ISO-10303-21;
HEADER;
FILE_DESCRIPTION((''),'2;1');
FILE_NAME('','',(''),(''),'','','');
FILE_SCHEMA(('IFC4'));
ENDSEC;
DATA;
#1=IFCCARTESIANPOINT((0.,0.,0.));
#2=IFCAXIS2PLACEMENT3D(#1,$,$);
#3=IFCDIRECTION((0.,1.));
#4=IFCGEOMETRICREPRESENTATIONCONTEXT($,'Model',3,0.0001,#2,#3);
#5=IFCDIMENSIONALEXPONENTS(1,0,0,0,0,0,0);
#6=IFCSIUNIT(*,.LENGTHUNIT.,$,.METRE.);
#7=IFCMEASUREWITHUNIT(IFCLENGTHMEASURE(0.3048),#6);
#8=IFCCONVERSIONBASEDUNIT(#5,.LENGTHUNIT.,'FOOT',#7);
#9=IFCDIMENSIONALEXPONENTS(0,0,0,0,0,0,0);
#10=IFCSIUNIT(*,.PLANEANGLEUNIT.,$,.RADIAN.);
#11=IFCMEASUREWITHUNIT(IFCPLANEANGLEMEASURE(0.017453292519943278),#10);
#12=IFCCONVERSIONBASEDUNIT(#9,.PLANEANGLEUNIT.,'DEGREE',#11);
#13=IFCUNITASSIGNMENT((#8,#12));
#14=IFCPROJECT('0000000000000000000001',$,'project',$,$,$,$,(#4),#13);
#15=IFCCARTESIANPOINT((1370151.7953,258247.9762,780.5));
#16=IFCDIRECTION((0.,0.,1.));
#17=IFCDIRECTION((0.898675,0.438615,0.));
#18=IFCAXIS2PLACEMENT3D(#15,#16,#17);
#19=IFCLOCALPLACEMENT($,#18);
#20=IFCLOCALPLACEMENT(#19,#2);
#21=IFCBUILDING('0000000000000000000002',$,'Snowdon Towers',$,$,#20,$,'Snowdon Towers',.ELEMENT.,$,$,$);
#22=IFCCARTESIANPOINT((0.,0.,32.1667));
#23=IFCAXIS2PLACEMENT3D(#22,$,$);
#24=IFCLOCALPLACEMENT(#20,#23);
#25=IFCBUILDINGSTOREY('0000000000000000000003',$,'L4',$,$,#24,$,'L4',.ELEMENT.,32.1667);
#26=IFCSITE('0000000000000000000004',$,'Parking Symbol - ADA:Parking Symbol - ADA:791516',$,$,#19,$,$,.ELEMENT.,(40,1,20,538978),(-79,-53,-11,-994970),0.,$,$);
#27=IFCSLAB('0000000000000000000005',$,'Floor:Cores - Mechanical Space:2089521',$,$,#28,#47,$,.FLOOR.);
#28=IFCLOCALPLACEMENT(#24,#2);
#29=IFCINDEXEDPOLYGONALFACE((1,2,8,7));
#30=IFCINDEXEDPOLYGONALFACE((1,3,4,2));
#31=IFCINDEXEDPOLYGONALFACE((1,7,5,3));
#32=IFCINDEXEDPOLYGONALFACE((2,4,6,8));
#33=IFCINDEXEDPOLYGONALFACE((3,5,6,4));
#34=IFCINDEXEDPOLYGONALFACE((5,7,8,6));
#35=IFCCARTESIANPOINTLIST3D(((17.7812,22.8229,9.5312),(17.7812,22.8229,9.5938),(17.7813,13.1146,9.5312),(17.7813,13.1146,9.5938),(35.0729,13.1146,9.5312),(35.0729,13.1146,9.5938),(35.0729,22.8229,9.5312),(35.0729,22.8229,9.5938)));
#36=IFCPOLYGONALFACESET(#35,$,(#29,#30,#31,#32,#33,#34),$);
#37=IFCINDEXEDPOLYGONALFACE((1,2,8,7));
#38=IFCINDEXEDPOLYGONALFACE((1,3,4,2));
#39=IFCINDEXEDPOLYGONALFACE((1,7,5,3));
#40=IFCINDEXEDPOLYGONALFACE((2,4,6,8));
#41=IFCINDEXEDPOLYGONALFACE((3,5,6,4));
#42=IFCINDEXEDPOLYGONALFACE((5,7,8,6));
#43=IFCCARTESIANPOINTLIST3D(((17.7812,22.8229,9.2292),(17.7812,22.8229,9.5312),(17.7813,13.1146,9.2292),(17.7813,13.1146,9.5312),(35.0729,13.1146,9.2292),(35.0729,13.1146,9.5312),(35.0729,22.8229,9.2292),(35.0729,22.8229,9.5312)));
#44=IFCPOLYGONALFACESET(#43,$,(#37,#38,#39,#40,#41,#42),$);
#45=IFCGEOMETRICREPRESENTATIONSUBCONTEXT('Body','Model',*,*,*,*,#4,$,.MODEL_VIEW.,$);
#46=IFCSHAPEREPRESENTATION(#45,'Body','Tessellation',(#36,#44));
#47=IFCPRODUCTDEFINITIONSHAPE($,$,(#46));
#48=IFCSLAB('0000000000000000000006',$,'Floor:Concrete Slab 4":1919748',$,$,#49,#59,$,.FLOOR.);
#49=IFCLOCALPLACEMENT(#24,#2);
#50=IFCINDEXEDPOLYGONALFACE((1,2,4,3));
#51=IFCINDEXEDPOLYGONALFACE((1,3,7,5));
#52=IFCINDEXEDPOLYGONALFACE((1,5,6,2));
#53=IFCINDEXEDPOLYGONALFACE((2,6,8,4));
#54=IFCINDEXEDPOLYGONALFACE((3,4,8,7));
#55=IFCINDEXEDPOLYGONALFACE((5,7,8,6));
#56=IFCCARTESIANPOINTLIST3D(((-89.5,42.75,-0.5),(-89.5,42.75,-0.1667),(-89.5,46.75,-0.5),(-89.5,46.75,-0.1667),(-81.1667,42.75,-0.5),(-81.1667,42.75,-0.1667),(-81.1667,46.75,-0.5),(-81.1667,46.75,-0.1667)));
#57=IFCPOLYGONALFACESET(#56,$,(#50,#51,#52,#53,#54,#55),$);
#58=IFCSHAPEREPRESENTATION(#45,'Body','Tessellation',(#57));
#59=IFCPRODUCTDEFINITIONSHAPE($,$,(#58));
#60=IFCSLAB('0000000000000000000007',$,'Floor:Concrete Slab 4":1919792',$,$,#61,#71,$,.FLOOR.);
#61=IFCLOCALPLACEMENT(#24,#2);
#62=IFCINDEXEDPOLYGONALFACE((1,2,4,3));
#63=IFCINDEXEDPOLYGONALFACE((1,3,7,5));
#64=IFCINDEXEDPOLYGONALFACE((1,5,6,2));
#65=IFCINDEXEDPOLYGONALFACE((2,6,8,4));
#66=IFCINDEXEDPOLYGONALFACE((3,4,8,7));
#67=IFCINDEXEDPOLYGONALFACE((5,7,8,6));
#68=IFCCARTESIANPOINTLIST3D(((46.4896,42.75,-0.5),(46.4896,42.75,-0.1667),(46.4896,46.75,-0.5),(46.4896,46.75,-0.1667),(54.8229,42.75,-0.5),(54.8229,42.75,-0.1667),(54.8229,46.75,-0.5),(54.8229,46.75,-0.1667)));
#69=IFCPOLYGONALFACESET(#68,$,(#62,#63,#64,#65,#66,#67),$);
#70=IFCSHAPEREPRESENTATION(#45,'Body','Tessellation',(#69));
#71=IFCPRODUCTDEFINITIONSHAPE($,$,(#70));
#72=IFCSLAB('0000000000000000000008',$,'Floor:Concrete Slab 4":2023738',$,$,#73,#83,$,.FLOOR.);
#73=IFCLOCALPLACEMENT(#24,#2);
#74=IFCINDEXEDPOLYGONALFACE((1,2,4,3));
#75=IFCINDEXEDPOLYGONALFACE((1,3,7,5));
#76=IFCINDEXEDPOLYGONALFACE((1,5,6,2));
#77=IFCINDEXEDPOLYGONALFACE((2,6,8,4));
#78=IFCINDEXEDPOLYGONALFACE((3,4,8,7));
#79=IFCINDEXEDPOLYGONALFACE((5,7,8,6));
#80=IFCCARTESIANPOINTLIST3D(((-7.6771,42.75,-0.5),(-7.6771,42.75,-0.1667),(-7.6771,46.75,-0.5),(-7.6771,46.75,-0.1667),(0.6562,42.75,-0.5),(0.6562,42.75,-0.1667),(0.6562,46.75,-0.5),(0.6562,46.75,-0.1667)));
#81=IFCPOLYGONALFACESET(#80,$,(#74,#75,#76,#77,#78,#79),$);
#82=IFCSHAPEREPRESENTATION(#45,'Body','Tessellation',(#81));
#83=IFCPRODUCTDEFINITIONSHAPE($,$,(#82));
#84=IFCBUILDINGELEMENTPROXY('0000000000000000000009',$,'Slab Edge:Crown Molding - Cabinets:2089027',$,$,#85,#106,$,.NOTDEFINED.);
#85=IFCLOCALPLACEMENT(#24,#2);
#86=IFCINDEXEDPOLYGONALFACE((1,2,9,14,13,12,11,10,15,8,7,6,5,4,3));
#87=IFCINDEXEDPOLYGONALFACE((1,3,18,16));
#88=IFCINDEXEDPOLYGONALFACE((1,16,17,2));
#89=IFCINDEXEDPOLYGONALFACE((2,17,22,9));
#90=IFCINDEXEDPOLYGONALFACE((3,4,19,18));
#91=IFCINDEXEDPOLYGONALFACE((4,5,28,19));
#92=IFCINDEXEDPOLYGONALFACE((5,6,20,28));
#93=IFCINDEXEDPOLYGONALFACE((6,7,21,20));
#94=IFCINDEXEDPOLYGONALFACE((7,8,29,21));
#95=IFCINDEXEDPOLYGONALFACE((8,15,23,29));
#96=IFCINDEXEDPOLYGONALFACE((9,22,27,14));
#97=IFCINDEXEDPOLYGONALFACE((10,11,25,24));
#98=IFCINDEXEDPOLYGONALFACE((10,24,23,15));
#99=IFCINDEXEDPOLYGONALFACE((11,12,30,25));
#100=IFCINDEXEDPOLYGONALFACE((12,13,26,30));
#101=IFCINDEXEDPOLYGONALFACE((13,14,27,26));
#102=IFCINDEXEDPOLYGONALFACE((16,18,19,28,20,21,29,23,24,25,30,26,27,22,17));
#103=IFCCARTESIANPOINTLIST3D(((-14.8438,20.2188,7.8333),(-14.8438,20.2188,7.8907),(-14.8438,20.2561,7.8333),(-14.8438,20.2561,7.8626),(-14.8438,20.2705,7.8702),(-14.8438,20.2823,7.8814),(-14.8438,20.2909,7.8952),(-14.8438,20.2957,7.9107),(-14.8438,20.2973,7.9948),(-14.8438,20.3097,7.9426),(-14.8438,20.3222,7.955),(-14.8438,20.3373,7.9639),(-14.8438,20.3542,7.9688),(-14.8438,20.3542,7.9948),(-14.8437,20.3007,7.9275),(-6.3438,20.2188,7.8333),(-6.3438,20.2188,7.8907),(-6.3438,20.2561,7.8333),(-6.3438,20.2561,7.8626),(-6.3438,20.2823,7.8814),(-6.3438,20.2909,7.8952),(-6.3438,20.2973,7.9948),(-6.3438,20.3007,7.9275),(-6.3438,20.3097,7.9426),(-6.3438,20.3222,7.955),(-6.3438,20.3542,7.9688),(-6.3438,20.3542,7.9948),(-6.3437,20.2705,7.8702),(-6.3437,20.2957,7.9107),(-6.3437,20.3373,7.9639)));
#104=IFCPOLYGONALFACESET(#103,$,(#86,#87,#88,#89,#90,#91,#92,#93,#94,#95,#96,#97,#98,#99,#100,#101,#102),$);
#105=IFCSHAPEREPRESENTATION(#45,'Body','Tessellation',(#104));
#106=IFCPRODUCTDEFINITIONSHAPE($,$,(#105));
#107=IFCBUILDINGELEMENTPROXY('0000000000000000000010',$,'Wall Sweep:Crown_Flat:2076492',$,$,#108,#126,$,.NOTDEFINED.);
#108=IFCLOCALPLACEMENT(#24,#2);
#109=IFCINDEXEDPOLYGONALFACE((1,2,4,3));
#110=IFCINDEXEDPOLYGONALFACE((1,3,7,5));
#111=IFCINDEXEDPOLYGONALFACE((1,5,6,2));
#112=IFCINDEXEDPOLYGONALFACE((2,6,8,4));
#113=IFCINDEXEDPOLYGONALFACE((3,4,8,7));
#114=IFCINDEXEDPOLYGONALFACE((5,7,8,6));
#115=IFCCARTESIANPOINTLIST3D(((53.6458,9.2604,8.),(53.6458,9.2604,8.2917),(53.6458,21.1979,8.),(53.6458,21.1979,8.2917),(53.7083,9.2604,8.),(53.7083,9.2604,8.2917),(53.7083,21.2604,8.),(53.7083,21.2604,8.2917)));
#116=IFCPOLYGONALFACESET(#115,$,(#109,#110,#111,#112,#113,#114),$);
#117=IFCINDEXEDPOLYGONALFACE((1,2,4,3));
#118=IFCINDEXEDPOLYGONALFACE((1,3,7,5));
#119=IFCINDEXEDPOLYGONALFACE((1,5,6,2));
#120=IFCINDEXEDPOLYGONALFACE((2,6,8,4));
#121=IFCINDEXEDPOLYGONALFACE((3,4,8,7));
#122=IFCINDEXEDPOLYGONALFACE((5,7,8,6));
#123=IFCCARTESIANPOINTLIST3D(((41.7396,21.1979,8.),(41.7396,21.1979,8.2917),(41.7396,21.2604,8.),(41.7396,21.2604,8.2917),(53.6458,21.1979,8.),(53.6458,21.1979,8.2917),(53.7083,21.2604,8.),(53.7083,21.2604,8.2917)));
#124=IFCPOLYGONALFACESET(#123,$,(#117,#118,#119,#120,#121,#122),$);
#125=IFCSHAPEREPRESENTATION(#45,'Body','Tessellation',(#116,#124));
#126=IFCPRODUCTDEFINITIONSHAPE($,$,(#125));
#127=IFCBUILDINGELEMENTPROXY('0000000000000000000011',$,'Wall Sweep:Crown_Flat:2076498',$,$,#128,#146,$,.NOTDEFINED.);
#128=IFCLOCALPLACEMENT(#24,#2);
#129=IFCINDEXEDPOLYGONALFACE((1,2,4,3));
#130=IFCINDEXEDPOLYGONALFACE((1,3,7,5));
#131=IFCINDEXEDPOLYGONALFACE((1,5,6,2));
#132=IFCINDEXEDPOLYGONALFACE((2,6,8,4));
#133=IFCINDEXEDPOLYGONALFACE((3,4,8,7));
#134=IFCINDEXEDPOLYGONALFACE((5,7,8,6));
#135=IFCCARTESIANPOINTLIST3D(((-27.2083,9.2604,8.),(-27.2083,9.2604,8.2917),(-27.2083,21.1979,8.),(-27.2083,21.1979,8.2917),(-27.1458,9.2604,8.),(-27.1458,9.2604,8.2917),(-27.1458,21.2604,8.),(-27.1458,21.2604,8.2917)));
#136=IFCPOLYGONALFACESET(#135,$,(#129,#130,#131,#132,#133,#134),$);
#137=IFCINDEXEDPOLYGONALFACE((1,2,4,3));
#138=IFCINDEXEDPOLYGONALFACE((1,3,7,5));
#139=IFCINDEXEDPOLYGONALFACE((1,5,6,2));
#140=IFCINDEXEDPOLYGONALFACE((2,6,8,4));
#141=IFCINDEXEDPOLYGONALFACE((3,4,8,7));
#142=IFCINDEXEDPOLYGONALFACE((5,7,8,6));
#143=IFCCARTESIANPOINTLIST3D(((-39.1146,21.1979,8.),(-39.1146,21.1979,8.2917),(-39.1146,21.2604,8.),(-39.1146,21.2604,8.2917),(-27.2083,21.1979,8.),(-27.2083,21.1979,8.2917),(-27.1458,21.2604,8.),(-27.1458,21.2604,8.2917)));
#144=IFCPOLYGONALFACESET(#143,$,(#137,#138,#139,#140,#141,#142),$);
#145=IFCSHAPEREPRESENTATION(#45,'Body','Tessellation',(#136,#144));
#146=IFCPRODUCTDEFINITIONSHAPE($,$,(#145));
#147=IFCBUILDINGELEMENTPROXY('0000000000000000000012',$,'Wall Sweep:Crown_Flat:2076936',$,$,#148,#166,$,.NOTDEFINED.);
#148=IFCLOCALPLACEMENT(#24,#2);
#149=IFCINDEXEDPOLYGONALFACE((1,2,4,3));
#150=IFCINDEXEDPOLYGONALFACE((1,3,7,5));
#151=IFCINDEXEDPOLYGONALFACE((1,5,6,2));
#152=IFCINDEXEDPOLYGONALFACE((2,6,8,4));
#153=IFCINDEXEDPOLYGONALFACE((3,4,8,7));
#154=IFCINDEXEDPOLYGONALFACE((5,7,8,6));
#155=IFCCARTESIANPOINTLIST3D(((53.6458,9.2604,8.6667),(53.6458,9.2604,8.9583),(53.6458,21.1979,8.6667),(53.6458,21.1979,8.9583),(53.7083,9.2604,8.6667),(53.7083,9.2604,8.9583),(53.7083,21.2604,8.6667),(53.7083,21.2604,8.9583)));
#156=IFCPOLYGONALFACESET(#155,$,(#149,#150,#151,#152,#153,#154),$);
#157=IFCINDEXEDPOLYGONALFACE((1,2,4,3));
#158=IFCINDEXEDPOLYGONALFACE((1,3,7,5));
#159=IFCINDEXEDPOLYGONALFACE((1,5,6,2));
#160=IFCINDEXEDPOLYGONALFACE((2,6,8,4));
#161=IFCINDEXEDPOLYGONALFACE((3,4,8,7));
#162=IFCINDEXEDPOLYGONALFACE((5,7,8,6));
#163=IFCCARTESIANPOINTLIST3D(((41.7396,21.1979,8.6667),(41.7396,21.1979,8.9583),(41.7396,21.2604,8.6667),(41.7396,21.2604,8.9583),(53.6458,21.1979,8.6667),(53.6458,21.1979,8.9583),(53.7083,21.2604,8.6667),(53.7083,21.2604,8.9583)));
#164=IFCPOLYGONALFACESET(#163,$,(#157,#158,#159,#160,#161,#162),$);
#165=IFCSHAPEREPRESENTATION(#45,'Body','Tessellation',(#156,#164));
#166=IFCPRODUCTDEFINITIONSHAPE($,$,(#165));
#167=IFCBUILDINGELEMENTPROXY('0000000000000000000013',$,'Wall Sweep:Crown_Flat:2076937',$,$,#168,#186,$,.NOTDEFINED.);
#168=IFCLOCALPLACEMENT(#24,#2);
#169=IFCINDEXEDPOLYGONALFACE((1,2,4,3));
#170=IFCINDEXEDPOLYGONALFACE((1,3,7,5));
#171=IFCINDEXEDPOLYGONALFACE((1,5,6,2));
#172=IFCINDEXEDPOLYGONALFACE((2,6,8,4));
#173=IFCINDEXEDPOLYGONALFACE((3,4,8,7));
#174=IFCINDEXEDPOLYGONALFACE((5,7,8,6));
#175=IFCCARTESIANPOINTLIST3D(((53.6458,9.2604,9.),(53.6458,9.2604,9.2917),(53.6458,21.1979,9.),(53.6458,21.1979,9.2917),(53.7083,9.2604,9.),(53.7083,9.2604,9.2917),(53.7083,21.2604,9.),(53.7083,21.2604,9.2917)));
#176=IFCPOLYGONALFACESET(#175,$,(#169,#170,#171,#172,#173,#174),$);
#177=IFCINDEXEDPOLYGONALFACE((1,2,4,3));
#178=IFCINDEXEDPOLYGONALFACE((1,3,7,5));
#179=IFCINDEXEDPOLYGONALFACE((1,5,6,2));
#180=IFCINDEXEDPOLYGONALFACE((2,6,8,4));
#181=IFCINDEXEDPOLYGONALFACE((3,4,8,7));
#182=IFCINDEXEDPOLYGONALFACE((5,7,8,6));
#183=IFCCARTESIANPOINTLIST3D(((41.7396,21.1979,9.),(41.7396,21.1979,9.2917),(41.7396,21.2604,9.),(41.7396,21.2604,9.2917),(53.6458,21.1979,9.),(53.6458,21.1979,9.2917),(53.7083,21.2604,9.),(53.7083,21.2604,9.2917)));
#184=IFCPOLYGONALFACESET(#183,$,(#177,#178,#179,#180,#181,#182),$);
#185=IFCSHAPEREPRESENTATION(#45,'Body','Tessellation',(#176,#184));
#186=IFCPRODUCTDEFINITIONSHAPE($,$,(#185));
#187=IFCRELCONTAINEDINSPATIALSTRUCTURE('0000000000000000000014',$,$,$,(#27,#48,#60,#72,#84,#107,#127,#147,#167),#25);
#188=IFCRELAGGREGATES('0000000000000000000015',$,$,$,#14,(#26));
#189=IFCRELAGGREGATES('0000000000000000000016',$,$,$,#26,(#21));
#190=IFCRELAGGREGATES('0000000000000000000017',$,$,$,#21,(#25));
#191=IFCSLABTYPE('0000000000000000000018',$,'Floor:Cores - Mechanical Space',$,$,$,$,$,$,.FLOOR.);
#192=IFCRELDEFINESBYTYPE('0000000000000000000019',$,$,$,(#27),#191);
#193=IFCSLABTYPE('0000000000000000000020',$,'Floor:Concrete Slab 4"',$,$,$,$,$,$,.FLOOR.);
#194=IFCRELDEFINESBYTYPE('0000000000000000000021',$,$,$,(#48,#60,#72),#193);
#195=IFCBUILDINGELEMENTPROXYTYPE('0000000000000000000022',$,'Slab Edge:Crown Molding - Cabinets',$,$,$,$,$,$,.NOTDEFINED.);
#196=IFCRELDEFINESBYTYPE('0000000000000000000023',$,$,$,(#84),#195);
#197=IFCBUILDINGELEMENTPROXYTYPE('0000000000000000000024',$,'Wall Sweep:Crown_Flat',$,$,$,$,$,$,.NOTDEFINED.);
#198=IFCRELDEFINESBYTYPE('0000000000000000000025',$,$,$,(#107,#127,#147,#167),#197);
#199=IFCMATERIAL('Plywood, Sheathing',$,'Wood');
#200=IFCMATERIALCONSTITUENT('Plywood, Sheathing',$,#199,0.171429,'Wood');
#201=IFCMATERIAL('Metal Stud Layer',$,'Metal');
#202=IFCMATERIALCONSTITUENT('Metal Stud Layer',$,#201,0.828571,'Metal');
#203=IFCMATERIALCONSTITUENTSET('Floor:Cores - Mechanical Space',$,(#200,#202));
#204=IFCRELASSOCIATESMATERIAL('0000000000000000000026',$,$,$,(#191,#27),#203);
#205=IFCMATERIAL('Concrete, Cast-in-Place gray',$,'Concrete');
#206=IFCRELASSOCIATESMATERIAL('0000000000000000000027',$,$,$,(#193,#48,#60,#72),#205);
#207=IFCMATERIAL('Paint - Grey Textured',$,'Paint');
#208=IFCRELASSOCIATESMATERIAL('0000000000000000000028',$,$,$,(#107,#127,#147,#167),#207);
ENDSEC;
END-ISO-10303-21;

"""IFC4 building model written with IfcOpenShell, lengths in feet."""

from ifc_helpers import new_model, entity, si_unit, converted_unit, direction, frame, origin, place, context, subcontext, project, spatial, line, arc, indexed_curve, outline, extrude, material, constituent, constituent_set, type_object, element, save


model = new_model("IFC4")

# Units and contexts
model_context = context("Model", 3, precision=0.0001, world=origin(), true_north=direction((0.0, 1.0)))
body_context = subcontext(model_context, "Body", "Model", "MODEL_VIEW")
ifc_project = project(units=[converted_unit("LENGTHUNIT", "FOOT", entity("IfcLengthMeasure", 0.3048), si_unit("LENGTHUNIT", "METRE"), dimensions=[1, 0, 0, 0, 0, 0, 0]), converted_unit("PLANEANGLEUNIT", "DEGREE", entity("IfcPlaneAngleMeasure", 0.017453292519943278), si_unit("PLANEANGLEUNIT", "RADIAN"), dimensions=[0, 0, 0, 0, 0, 0, 0])], contexts=[model_context])

# Site, building, storey
site_placement = place(None, frame((1370151.7953, 258247.9762, 780.5), z_axis=(0.0, 0.0, 1.0), x_axis=(0.898675, 0.438615, 0.0)))
site = spatial("IfcSite", under=ifc_project, at=site_placement, Name="Parking Symbol - ADA:Parking Symbol - ADA:791516", CompositionType="ELEMENT", RefLatitude=(40, 1, 20, 538978), RefLongitude=(-79, -53, -11, -994970), RefElevation=0.0)
building_placement = place(site_placement, origin())
building = spatial("IfcBuilding", under=site, at=building_placement, Name="Snowdon Towers", LongName="Snowdon Towers", CompositionType="ELEMENT")
storey_placement = place(building_placement, frame((0.0, 0.0, 32.1667)))
storey = spatial("IfcBuildingStorey", under=building, at=storey_placement, Name="L4", LongName="L4", CompositionType="ELEMENT", Elevation=32.1667)

# Slabs
ifc_material_1 = material(Name="Plywood, Sheathing", Category="Wood")
ifc_constituent_1 = constituent(ifc_material_1, Name="Plywood, Sheathing", Category="Wood", fraction=0.171429)
ifc_material_2 = material(Name="Metal Stud Layer", Category="Metal")
ifc_constituent_2 = constituent(ifc_material_2, Name="Metal Stud Layer", Category="Metal", fraction=0.828571)
ifc_constituent_set_1 = constituent_set(constituents=[ifc_constituent_1, ifc_constituent_2], Name="Floor:Cores - Mechanical Space")
slab_type_1 = type_object("IfcSlabType", Name="Floor:Cores - Mechanical Space", PredefinedType="FLOOR", material=ifc_constituent_set_1)
slab_1_placement = place(storey_placement, origin())
element("IfcSlab", 1, at=slab_1_placement, inside=storey, type_object=slab_type_1, material=ifc_constituent_set_1, Name="Floor:Cores - Mechanical Space:2089521", PredefinedType="FLOOR", context=body_context, shape_type="SweptSolid", body=[
    extrude(outline(indexed_curve([(-4.8542, -8.6458), (4.8542, -8.6458), (4.8542, 8.6458), (-4.8542, 8.6458), (-4.8542, -8.6458)], self_intersect=False)), frame((26.4271, 17.9687, 9.5312), z_axis=(0.0, 0.0, 1.0), x_axis=(0.0, -1.0, 0.0)), (0.0, 0.0, 1.0), 0.0625),
    extrude(outline(indexed_curve([(-4.8542, -8.6458), (4.8542, -8.6458), (4.8542, 8.6458), (-4.8542, 8.6458), (-4.8542, -8.6458)], self_intersect=False)), frame((26.4271, 17.9687, 9.2292), z_axis=(0.0, 0.0, 1.0), x_axis=(0.0, 1.0, 0.0)), (0.0, 0.0, 1.0), 0.3021),
])
ifc_material_3 = material(Name="Concrete, Cast-in-Place gray", Category="Concrete")
slab_type_2 = type_object("IfcSlabType", Name="Floor:Concrete Slab 4\"", PredefinedType="FLOOR", material=ifc_material_3)
slab_2_placement = place(storey_placement, origin())
element("IfcSlab", 2, at=slab_2_placement, inside=storey, type_object=slab_type_2, material=ifc_material_3, Name="Floor:Concrete Slab 4\":1919748", PredefinedType="FLOOR", context=body_context, shape_type="SweptSolid", body=[
    extrude(outline(indexed_curve([(-2.0, -4.1667), (2.0, -4.1667), (2.0, 4.1667), (-2.0, 4.1667), (-2.0, -4.1667)], self_intersect=False)), frame((-85.3333, 44.75, -0.1667), z_axis=(0.0, 0.0, -1.0), x_axis=(0.0, 1.0, 0.0)), (0.0, 0.0, 1.0), 0.3333),
])
slab_3_placement = place(storey_placement, origin())
element("IfcSlab", 3, at=slab_3_placement, inside=storey, type_object=slab_type_2, material=ifc_material_3, Name="Floor:Concrete Slab 4\":1919792", PredefinedType="FLOOR", context=body_context, shape_type="SweptSolid", body=[
    extrude(outline(indexed_curve([(-2.0, -4.1667), (2.0, -4.1667), (2.0, 4.1667), (-2.0, 4.1667), (-2.0, -4.1667)], self_intersect=False)), frame((50.6563, 44.75, -0.1667), z_axis=(0.0, 0.0, -1.0), x_axis=(0.0, 1.0, 0.0)), (0.0, 0.0, 1.0), 0.3333),
])
slab_4_placement = place(storey_placement, origin())
element("IfcSlab", 4, at=slab_4_placement, inside=storey, type_object=slab_type_2, material=ifc_material_3, Name="Floor:Concrete Slab 4\":2023738", PredefinedType="FLOOR", context=body_context, shape_type="SweptSolid", body=[
    extrude(outline(indexed_curve([(-2.0, -4.1667), (2.0, -4.1667), (2.0, 4.1667), (-2.0, 4.1667), (-2.0, -4.1667)], self_intersect=False)), frame((-3.5104, 44.75, -0.1667), z_axis=(0.0, 0.0, -1.0), x_axis=(0.0, 1.0, 0.0)), (0.0, 0.0, 1.0), 0.3333),
])

# Building element proxies
building_element_proxy_type_1 = type_object("IfcBuildingElementProxyType", Name="Slab Edge:Crown Molding - Cabinets", PredefinedType="NOTDEFINED")
proxy_1_placement = place(storey_placement, origin())
element("IfcBuildingElementProxy", 5, at=proxy_1_placement, inside=storey, type_object=building_element_proxy_type_1, Name="Slab Edge:Crown Molding - Cabinets:2089027", PredefinedType="NOTDEFINED", context=body_context, shape_type="SweptSolid", body=[
    extrude(outline(indexed_curve([(-0.0764, -0.0377), (0.054, -0.0377), (0.0998, -0.0031), (0.0773, 0.0267), (0.054, 0.0091), (0.0232, 0.0187), (-0.0083, 0.0116), (-0.051, 0.0044), (-0.0898, 0.0234), (-0.1106, 0.0077)], segments=[line(1, 2, 3, 4, 5), arc(5, 6, 7), arc(7, 8, 9), line(9, 10, 1)], self_intersect=False)), frame((-14.8437, 20.2814, 7.9111), z_axis=(1.0, 0.0, 0.0), x_axis=(0.0, -0.602405, -0.798191)), (0.0, 0.0, 1.0), 8.5),
])
ifc_material_4 = material(Name="Paint - Grey Textured", Category="Paint")
building_element_proxy_type_2 = type_object("IfcBuildingElementProxyType", Name="Wall Sweep:Crown_Flat", PredefinedType="NOTDEFINED")
proxy_2_placement = place(storey_placement, origin())
element("IfcBuildingElementProxy", 6, at=proxy_2_placement, inside=storey, type_object=building_element_proxy_type_2, material=ifc_material_4, Name="Wall Sweep:Crown_Flat:2076492", PredefinedType="NOTDEFINED", context=body_context, shape_type="SweptSolid", body=[
    extrude(outline(indexed_curve([(-5.9531, -0.0312), (5.9844, -0.0312), (5.9844, 0.0312), (-6.0156, 0.0312), (-5.9531, -0.0312)], self_intersect=False)), frame((53.6771, 15.2448, 8.0), z_axis=(0.0, 0.0, 1.0), x_axis=(0.0, -1.0, 0.0)), (0.0, 0.0, 1.0), 0.2917),
    extrude(outline(indexed_curve([(-5.9688, -0.0312), (5.9375, -0.0312), (6.0, 0.0313), (-5.9688, 0.0313), (-5.9688, -0.0312)], self_intersect=False)), frame((47.7083, 21.2292, 8.0)), (0.0, 0.0, 1.0), 0.2917),
])
proxy_3_placement = place(storey_placement, origin())
element("IfcBuildingElementProxy", 7, at=proxy_3_placement, inside=storey, type_object=building_element_proxy_type_2, material=ifc_material_4, Name="Wall Sweep:Crown_Flat:2076498", PredefinedType="NOTDEFINED", context=body_context, shape_type="SweptSolid", body=[
    extrude(outline(indexed_curve([(-5.9531, -0.0312), (5.9844, -0.0312), (5.9844, 0.0312), (-6.0156, 0.0312), (-5.9531, -0.0312)], self_intersect=False)), frame((-27.1771, 15.2448, 8.0), z_axis=(0.0, 0.0, 1.0), x_axis=(0.0, -1.0, 0.0)), (0.0, 0.0, 1.0), 0.2917),
    extrude(outline(indexed_curve([(-5.9688, -0.0312), (5.9375, -0.0312), (6.0, 0.0313), (-5.9688, 0.0313), (-5.9688, -0.0312)], self_intersect=False)), frame((-33.1458, 21.2292, 8.0)), (0.0, 0.0, 1.0), 0.2917),
])
proxy_4_placement = place(storey_placement, origin())
element("IfcBuildingElementProxy", 8, at=proxy_4_placement, inside=storey, type_object=building_element_proxy_type_2, material=ifc_material_4, Name="Wall Sweep:Crown_Flat:2076936", PredefinedType="NOTDEFINED", context=body_context, shape_type="SweptSolid", body=[
    extrude(outline(indexed_curve([(-5.9531, -0.0312), (5.9844, -0.0312), (5.9844, 0.0312), (-6.0156, 0.0312), (-5.9531, -0.0312)], self_intersect=False)), frame((53.6771, 15.2448, 8.6667), z_axis=(0.0, 0.0, 1.0), x_axis=(0.0, -1.0, 0.0)), (0.0, 0.0, 1.0), 0.2917),
    extrude(outline(indexed_curve([(-5.9688, -0.0312), (5.9375, -0.0312), (6.0, 0.0313), (-5.9688, 0.0313), (-5.9688, -0.0312)], self_intersect=False)), frame((47.7083, 21.2292, 8.6667)), (0.0, 0.0, 1.0), 0.2917),
])
proxy_5_placement = place(storey_placement, origin())
element("IfcBuildingElementProxy", 9, at=proxy_5_placement, inside=storey, type_object=building_element_proxy_type_2, material=ifc_material_4, Name="Wall Sweep:Crown_Flat:2076937", PredefinedType="NOTDEFINED", context=body_context, shape_type="SweptSolid", body=[
    extrude(outline(indexed_curve([(-5.9531, -0.0312), (5.9844, -0.0312), (5.9844, 0.0312), (-6.0156, 0.0312), (-5.9531, -0.0312)], self_intersect=False)), frame((53.6771, 15.2448, 9.0), z_axis=(0.0, 0.0, 1.0), x_axis=(0.0, -1.0, 0.0)), (0.0, 0.0, 1.0), 0.2917),
    extrude(outline(indexed_curve([(-5.9688, -0.0312), (5.9375, -0.0312), (6.0, 0.0313), (-5.9688, 0.0313), (-5.9688, -0.0312)], self_intersect=False)), frame((47.7083, 21.2292, 9.0)), (0.0, 0.0, 1.0), 0.2917),
])

save(model, "model.ifc")
